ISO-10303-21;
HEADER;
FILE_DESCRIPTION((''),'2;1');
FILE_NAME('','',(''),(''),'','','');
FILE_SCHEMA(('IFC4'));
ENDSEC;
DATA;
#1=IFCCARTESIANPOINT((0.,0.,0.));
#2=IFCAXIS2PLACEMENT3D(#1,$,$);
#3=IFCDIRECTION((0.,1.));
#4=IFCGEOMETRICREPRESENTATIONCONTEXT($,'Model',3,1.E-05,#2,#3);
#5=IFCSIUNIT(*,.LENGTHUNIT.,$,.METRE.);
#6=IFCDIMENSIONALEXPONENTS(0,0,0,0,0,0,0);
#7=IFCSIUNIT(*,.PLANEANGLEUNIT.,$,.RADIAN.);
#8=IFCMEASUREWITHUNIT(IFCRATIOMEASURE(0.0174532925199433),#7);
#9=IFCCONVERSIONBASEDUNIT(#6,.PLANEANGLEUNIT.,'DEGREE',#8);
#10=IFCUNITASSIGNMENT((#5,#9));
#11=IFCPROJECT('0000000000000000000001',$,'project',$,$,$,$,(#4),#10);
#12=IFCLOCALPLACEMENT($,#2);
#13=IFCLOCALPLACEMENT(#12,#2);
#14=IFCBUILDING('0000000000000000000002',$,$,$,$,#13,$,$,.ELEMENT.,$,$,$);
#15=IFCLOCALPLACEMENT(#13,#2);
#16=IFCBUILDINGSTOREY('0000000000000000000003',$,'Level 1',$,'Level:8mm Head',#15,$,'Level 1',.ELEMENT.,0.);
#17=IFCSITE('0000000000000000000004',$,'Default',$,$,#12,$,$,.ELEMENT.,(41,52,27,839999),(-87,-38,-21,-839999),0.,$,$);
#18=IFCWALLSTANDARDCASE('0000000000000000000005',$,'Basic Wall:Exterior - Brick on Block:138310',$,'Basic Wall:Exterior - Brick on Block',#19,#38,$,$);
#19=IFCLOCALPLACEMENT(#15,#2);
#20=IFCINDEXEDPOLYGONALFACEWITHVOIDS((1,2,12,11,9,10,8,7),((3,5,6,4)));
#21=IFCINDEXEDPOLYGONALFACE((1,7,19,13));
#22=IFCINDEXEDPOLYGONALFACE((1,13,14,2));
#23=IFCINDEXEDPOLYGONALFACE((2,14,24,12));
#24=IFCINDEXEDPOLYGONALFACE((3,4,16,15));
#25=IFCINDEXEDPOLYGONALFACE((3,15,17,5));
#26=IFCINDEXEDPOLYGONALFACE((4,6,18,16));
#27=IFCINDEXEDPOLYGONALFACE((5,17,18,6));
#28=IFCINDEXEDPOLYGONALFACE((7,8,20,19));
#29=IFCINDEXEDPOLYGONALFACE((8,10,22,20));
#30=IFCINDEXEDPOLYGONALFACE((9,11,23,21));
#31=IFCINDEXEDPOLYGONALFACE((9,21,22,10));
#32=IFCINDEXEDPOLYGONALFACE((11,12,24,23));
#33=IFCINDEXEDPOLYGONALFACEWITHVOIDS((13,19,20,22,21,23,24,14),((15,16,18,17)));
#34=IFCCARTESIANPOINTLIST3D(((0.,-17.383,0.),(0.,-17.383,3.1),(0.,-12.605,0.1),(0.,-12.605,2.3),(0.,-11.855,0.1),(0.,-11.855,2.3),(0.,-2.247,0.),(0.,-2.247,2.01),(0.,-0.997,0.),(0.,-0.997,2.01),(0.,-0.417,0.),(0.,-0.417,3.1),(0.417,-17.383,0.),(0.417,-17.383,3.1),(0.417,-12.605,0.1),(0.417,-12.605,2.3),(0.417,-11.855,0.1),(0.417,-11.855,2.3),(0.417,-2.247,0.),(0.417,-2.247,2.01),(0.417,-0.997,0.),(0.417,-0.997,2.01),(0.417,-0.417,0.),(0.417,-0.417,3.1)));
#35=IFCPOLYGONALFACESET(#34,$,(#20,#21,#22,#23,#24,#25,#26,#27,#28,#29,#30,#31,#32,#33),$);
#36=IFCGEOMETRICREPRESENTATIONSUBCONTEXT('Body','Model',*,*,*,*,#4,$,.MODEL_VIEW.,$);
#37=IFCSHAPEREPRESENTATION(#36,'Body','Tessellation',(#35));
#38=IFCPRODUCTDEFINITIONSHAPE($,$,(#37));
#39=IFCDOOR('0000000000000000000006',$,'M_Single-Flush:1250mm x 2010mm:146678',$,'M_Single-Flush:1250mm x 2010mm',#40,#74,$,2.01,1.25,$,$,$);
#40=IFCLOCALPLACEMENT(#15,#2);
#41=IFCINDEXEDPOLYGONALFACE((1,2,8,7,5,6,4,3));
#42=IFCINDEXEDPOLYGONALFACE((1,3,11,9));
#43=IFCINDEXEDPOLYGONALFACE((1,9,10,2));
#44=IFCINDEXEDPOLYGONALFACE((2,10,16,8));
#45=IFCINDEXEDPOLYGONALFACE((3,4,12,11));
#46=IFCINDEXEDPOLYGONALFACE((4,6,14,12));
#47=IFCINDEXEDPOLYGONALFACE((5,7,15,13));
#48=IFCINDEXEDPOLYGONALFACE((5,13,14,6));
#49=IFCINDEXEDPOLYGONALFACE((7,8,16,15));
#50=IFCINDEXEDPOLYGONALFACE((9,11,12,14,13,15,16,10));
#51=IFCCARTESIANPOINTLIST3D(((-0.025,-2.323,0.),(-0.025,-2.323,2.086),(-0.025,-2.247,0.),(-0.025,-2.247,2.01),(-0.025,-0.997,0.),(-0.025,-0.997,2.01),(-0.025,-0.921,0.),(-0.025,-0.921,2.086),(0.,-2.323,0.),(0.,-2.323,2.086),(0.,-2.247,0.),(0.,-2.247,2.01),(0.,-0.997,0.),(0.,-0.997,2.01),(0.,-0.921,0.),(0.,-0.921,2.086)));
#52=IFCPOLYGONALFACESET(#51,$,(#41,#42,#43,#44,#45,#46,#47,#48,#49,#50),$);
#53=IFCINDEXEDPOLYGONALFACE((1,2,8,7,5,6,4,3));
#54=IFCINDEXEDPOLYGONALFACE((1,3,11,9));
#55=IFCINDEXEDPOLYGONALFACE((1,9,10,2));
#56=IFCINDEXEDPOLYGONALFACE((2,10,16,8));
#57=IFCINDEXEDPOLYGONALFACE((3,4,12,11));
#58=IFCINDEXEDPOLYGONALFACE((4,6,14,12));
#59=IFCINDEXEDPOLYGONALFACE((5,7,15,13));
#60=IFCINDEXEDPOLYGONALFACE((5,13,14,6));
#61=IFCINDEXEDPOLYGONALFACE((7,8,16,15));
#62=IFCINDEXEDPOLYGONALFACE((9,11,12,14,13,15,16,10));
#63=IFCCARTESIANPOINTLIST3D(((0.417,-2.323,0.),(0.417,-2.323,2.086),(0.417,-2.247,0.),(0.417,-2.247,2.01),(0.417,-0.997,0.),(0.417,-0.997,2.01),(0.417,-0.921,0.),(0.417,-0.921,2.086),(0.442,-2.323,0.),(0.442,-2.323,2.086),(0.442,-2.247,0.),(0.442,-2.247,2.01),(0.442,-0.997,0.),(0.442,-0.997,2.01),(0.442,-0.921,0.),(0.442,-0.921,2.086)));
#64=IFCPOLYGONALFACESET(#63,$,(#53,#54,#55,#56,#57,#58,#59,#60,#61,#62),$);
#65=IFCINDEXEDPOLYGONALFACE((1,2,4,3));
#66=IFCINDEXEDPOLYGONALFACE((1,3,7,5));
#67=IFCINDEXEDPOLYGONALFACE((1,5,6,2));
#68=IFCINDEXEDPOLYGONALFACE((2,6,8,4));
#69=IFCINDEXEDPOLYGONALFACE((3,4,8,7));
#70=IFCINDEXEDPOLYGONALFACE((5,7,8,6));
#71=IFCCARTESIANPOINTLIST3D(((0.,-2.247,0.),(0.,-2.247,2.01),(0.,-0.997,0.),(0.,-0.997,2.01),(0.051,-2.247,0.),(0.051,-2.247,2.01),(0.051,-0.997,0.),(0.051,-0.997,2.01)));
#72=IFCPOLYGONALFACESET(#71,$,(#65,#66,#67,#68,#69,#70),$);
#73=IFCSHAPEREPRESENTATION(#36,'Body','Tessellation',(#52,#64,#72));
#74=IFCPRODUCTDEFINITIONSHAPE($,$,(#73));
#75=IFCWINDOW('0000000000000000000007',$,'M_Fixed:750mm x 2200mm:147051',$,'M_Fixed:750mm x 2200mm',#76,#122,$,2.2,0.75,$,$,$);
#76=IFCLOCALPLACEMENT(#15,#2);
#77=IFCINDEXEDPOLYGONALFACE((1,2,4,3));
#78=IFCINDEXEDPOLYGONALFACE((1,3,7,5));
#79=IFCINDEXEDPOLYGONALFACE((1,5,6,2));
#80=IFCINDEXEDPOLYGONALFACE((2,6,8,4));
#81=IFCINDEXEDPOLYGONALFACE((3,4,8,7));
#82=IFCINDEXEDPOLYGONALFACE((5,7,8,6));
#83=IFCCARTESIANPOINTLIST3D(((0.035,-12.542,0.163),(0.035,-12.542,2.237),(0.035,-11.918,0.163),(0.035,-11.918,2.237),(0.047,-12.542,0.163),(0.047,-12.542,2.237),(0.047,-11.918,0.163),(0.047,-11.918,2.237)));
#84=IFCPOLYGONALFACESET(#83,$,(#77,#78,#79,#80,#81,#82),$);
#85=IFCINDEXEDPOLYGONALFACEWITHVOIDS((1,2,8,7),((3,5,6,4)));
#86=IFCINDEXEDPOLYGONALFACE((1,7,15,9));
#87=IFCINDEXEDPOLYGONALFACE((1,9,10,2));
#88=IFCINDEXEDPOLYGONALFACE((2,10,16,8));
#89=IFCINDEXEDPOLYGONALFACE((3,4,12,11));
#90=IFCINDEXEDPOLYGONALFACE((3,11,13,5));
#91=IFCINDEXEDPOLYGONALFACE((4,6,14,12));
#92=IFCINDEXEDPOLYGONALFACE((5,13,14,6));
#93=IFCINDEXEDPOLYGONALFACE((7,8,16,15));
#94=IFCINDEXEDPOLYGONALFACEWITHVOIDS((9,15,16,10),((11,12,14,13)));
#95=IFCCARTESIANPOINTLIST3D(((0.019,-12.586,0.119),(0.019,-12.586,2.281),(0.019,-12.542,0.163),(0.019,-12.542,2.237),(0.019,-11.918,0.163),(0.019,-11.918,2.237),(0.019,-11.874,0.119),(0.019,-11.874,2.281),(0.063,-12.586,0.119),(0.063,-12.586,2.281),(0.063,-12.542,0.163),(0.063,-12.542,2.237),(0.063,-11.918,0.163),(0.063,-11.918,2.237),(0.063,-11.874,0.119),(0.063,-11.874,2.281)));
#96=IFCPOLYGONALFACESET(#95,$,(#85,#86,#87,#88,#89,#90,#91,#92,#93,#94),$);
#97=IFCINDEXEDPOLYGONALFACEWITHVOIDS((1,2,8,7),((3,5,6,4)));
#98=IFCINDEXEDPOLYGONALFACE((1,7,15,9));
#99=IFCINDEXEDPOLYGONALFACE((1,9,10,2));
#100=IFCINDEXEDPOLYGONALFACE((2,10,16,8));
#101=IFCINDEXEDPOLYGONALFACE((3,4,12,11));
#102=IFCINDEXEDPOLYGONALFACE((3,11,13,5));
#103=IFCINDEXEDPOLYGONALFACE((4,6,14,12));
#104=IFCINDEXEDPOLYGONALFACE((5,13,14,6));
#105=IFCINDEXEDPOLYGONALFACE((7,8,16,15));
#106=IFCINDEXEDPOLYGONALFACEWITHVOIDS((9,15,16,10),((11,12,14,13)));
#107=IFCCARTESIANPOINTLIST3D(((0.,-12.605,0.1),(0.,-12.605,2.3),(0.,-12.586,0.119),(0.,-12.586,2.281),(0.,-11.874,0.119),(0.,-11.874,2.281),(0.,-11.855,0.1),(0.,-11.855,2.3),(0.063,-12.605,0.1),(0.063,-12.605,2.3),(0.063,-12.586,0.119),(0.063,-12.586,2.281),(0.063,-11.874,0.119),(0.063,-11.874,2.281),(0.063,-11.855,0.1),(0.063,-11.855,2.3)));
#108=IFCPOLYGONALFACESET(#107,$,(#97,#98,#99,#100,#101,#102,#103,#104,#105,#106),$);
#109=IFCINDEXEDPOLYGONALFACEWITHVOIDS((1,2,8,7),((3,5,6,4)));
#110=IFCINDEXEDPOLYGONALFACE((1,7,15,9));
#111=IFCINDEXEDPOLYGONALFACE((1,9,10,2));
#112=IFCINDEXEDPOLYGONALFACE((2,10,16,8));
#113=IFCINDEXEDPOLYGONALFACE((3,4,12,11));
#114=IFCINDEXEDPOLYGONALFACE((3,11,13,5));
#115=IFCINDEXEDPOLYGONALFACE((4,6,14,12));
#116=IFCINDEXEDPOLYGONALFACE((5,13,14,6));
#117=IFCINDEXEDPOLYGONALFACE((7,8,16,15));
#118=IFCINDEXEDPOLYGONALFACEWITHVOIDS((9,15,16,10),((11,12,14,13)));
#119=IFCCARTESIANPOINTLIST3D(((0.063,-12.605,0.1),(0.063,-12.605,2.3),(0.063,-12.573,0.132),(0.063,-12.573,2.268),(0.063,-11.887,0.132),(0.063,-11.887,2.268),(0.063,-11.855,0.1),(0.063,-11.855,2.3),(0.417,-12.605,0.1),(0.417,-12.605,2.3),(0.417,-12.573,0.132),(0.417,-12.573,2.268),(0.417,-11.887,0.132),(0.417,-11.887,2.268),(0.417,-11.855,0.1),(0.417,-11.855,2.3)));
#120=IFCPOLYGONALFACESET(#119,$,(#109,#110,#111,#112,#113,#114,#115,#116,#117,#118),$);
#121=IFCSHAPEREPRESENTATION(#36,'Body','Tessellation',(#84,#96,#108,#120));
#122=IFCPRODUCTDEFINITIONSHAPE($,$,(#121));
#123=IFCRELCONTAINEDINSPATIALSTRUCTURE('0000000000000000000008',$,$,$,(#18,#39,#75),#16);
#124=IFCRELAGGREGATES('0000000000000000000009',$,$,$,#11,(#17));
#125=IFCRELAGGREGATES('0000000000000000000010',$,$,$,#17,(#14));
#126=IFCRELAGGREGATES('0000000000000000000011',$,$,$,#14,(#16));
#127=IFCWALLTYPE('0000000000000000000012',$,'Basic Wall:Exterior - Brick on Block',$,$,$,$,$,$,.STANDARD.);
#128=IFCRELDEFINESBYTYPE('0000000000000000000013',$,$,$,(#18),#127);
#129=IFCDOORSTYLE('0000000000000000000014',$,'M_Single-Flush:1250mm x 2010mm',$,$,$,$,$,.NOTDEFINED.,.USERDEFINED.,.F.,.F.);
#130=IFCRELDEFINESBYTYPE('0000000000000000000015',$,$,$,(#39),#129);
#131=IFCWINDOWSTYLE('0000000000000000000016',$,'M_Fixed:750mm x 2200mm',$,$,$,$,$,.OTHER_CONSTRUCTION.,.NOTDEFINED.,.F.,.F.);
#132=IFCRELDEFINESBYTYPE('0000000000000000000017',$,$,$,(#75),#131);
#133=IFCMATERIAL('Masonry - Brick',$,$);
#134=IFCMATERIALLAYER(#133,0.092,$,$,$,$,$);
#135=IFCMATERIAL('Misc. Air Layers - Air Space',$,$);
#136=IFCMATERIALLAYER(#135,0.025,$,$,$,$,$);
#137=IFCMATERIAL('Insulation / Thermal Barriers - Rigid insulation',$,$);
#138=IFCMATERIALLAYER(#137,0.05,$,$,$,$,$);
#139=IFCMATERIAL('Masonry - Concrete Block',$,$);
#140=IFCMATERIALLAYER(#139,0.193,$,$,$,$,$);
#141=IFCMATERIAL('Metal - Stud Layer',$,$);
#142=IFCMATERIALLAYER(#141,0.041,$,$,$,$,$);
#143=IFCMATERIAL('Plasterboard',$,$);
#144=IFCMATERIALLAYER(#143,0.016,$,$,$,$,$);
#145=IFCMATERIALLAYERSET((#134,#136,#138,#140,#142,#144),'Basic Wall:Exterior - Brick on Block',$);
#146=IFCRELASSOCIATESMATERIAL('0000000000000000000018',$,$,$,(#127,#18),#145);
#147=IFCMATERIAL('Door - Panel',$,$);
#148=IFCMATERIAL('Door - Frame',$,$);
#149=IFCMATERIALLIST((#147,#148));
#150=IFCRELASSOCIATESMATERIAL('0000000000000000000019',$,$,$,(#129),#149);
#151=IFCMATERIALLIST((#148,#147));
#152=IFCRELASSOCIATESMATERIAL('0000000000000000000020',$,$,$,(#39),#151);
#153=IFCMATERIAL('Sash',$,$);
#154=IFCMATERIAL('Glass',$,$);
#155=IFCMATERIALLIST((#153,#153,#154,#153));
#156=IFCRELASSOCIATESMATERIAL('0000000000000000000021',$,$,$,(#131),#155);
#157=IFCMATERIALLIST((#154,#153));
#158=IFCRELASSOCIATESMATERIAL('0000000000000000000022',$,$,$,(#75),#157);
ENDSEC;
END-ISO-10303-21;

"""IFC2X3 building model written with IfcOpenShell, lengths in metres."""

from ifc_helpers import new_model, entity, si_unit, converted_unit, direction, frame, frame_2d, origin, origin_2d_with_axis, place, context, subcontext, project, spatial, polyline, rectangle, outline, extrude, source, transform, mapped, material, material_list, layer, layer_set, layer_usage, type_object, type_shapes, element, fill, save


model = new_model("IFC2X3")

# Units and contexts
model_context = context("Model", 3, precision=1e-05, world=origin(), true_north=direction((0.0, 1.0)))
body_context = subcontext(model_context, "Body", "Model", "MODEL_VIEW")
ifc_project = project(units=[si_unit("LENGTHUNIT", "METRE"), converted_unit("PLANEANGLEUNIT", "DEGREE", entity("IfcRatioMeasure", 0.0174532925199433), si_unit("PLANEANGLEUNIT", "RADIAN"), dimensions=[0, 0, 0, 0, 0, 0, 0])], contexts=[model_context])

# Site, building, storey
site_placement = place(None, origin())
site = spatial("IfcSite", under=ifc_project, at=site_placement, Name="Default", CompositionType="ELEMENT", RefLatitude=(41, 52, 27, 839999), RefLongitude=(-87, -38, -21, -839999), RefElevation=0.0)
building_placement = place(site_placement, origin())
building = spatial("IfcBuilding", under=site, at=building_placement, CompositionType="ELEMENT")
storey_placement = place(building_placement, origin())
storey = spatial("IfcBuildingStorey", under=building, at=storey_placement, Name="Level 1", ObjectType="Level:8mm Head", LongName="Level 1", CompositionType="ELEMENT", Elevation=0.0)

# Shared definitions
ifc_material_1 = material(Name="Masonry - Brick")
ifc_layer_1 = layer(ifc_material_1, 0.092)
ifc_material_2 = material(Name="Misc. Air Layers - Air Space")
ifc_layer_2 = layer(ifc_material_2, 0.025)
ifc_material_3 = material(Name="Insulation / Thermal Barriers - Rigid insulation")
ifc_layer_3 = layer(ifc_material_3, 0.05)
ifc_material_4 = material(Name="Masonry - Concrete Block")
ifc_layer_4 = layer(ifc_material_4, 0.193)
ifc_material_5 = material(Name="Metal - Stud Layer")
ifc_layer_5 = layer(ifc_material_5, 0.041)
ifc_material_6 = material(Name="Plasterboard")
ifc_layer_6 = layer(ifc_material_6, 0.016)
ifc_layer_set_1 = layer_set([ifc_layer_1, ifc_layer_2, ifc_layer_3, ifc_layer_4, ifc_layer_5, ifc_layer_6], Name="Basic Wall:Exterior - Brick on Block")
wall_type_1 = type_object("IfcWallType", Name="Basic Wall:Exterior - Brick on Block", PredefinedType="STANDARD", material=ifc_layer_set_1)
ifc_material_7 = material(Name="Glass")
ifc_material_8 = material(Name="Sash")
ifc_material_9 = material(Name="Door - Frame")
ifc_material_10 = material(Name="Door - Panel")

# Wall, openings, door, window
ifc_layer_usage_1 = layer_usage(ifc_layer_set_1, "AXIS2", "NEGATIVE", 0.2085)
wall_1_placement = place(storey_placement, frame((0.2085, -17.383, 0.0), z_axis=(0.0, 0.0, 1.0), x_axis=(0.0, 1.0, 0.0)))
wall_1 = element("IfcWallStandardCase", 1, at=wall_1_placement, inside=storey, type_object=wall_type_1, material=ifc_layer_usage_1, Name="Basic Wall:Exterior - Brick on Block:138310", ObjectType="Basic Wall:Exterior - Brick on Block", context=body_context, shape_type="SweptSolid", body=[
    extrude(rectangle(XDim=16.966, YDim=0.417, at=frame_2d((8.483, 0.0), x_axis=(-1.0, 0.0))), origin(), (0.0, 0.0, 1.0), 3.1),
])
opening_1_placement = place(wall_1_placement, frame((15.136, -0.2085, 0.0)))
opening_1 = element("IfcOpeningElement", 2, at=opening_1_placement, cuts=wall_1, ObjectType="Opening", context=body_context, shape_type="SweptSolid", body=[
    extrude(rectangle(XDim=1.25, YDim=2.01, at=frame_2d((1.005, 0.625), x_axis=(0.0, 1.0))), frame((0.0, 0.0, 0.0), z_axis=(0.0, 1.0, 0.0), x_axis=(0.0, 0.0, 1.0)), (0.0, 0.0, 1.0), 0.417),
])
opening_2_placement = place(wall_1_placement, frame((4.778, -0.2085, 0.1)))
opening_2 = element("IfcOpeningElement", 3, at=opening_2_placement, cuts=wall_1, ObjectType="Opening", context=body_context, shape_type="SweptSolid", body=[
    extrude(rectangle(XDim=2.2, YDim=0.75, at=frame_2d((1.1, 0.375), x_axis=(1.0, 0.0))), frame((0.0, 0.0, 0.0), z_axis=(0.0, 1.0, 0.0), x_axis=(0.0, 0.0, 1.0)), (0.0, 0.0, 1.0), 0.417),
])
ifc_material_list_1 = material_list([ifc_material_9, ifc_material_10])
ifc_material_list_2 = material_list([ifc_material_10, ifc_material_9])
door_style_1 = type_object("IfcDoorStyle", Name="M_Single-Flush:1250mm x 2010mm", ConstructionType="USERDEFINED", OperationType="NOTDEFINED", ParameterTakesPrecedence=False, Sizeable=False, material=ifc_material_list_2)
shared_shape_1 = source(origin(), body_context, "Body", "SweptSolid", [
    extrude(outline(polyline([(-0.701, -1.062), (0.701, -1.062), (0.701, 1.024), (0.625, 1.024), (0.625, -0.986), (-0.625, -0.986), (-0.625, 1.024), (-0.701, 1.024), (-0.701, -1.062)])), frame((0.625, 0.417, 1.024), z_axis=(0.0, 1.0, 0.0), x_axis=(1.0, 0.0, 0.0)), (0.0, 0.0, 1.0), 0.025),
    extrude(outline(polyline([(-1.062, -0.701), (1.024, -0.701), (1.024, -0.625), (-0.986, -0.625), (-0.986, 0.625), (1.024, 0.625), (1.024, 0.701), (-1.062, 0.701), (-1.062, -0.701)])), frame((0.625, -0.025, 1.024), z_axis=(0.0, 1.0, 0.0), x_axis=(0.0, 0.0, -1.0)), (0.0, 0.0, 1.0), 0.025),
    extrude(rectangle(XDim=0.051, YDim=1.25, at=frame_2d((0.0, 0.0), x_axis=(1.0, 0.0))), frame((0.625, 0.3915, 0.0), z_axis=(0.0, 0.0, 1.0), x_axis=(0.0, 1.0, 0.0)), (0.0, 0.0, 1.0), 2.01),
])
type_shapes(door_style_1, [shared_shape_1])
door_1_placement = place(opening_1_placement, origin())
door_1 = element("IfcDoor", 4, at=door_1_placement, inside=storey, type_object=door_style_1, material=ifc_material_list_1, Name="M_Single-Flush:1250mm x 2010mm:146678", ObjectType="M_Single-Flush:1250mm x 2010mm", OverallHeight=2.01, OverallWidth=1.25, context=body_context, shape_type="MappedRepresentation", body=[
    mapped(shared_shape_1, transform((0.0, 0.0, 0.0), scale=1.0)),
])
fill(opening_1, door_1)
ifc_material_list_3 = material_list([ifc_material_7, ifc_material_8])
ifc_material_list_4 = material_list([ifc_material_8, ifc_material_8, ifc_material_7, ifc_material_8])
window_style_1 = type_object("IfcWindowStyle", Name="M_Fixed:750mm x 2200mm", ConstructionType="OTHER_CONSTRUCTION", OperationType="NOTDEFINED", ParameterTakesPrecedence=False, Sizeable=False, material=ifc_material_list_4)
shared_shape_2 = source(origin(), body_context, "Body", "SweptSolid", [
    extrude(rectangle(XDim=0.012, YDim=0.624, at=origin_2d_with_axis()), frame((0.375, 0.376, 0.063), z_axis=(0.0, 0.0, 1.0), x_axis=(0.0, -1.0, 0.0)), (0.0, 0.0, 1.0), 2.074),
    extrude(outline(polyline([(-0.356, -1.081), (0.356, -1.081), (0.356, 1.081), (-0.356, 1.081), (-0.356, -1.081)]), holes=[polyline([(-0.312, -1.037), (-0.312, 1.037), (0.312, 1.037), (0.312, -1.037), (-0.312, -1.037)])]), frame((0.375, 0.354, 1.1), z_axis=(0.0, 1.0, 0.0), x_axis=(1.0, 0.0, 0.0)), (0.0, 0.0, 1.0), 0.044),
    extrude(outline(polyline([(-0.375, -1.1), (0.375, -1.1), (0.375, 1.1), (-0.375, 1.1), (-0.375, -1.1)]), holes=[polyline([(-0.356, -1.081), (-0.356, 1.081), (0.356, 1.081), (0.356, -1.081), (-0.356, -1.081)])]), frame((0.375, 0.354, 1.1), z_axis=(0.0, 1.0, 0.0), x_axis=(1.0, 0.0, 0.0)), (0.0, 0.0, 1.0), 0.063),
    extrude(outline(polyline([(-0.375, -1.1), (0.375, -1.1), (0.375, 1.1), (-0.375, 1.1), (-0.375, -1.1)]), holes=[polyline([(-0.343, -1.068), (-0.343, 1.068), (0.343, 1.068), (0.343, -1.068), (-0.343, -1.068)])]), frame((0.375, 0.0, 1.1), z_axis=(0.0, 1.0, 0.0), x_axis=(1.0, 0.0, 0.0)), (0.0, 0.0, 1.0), 0.354),
])
type_shapes(window_style_1, [shared_shape_2])
window_1_placement = place(opening_2_placement, origin())
window_1 = element("IfcWindow", 5, at=window_1_placement, inside=storey, type_object=window_style_1, material=ifc_material_list_3, Name="M_Fixed:750mm x 2200mm:147051", ObjectType="M_Fixed:750mm x 2200mm", OverallHeight=2.2, OverallWidth=0.75, context=body_context, shape_type="MappedRepresentation", body=[
    mapped(shared_shape_2, transform((0.0, 0.0, 0.0), scale=1.0)),
])
fill(opening_2, window_1)

save(model, "model.ifc")
